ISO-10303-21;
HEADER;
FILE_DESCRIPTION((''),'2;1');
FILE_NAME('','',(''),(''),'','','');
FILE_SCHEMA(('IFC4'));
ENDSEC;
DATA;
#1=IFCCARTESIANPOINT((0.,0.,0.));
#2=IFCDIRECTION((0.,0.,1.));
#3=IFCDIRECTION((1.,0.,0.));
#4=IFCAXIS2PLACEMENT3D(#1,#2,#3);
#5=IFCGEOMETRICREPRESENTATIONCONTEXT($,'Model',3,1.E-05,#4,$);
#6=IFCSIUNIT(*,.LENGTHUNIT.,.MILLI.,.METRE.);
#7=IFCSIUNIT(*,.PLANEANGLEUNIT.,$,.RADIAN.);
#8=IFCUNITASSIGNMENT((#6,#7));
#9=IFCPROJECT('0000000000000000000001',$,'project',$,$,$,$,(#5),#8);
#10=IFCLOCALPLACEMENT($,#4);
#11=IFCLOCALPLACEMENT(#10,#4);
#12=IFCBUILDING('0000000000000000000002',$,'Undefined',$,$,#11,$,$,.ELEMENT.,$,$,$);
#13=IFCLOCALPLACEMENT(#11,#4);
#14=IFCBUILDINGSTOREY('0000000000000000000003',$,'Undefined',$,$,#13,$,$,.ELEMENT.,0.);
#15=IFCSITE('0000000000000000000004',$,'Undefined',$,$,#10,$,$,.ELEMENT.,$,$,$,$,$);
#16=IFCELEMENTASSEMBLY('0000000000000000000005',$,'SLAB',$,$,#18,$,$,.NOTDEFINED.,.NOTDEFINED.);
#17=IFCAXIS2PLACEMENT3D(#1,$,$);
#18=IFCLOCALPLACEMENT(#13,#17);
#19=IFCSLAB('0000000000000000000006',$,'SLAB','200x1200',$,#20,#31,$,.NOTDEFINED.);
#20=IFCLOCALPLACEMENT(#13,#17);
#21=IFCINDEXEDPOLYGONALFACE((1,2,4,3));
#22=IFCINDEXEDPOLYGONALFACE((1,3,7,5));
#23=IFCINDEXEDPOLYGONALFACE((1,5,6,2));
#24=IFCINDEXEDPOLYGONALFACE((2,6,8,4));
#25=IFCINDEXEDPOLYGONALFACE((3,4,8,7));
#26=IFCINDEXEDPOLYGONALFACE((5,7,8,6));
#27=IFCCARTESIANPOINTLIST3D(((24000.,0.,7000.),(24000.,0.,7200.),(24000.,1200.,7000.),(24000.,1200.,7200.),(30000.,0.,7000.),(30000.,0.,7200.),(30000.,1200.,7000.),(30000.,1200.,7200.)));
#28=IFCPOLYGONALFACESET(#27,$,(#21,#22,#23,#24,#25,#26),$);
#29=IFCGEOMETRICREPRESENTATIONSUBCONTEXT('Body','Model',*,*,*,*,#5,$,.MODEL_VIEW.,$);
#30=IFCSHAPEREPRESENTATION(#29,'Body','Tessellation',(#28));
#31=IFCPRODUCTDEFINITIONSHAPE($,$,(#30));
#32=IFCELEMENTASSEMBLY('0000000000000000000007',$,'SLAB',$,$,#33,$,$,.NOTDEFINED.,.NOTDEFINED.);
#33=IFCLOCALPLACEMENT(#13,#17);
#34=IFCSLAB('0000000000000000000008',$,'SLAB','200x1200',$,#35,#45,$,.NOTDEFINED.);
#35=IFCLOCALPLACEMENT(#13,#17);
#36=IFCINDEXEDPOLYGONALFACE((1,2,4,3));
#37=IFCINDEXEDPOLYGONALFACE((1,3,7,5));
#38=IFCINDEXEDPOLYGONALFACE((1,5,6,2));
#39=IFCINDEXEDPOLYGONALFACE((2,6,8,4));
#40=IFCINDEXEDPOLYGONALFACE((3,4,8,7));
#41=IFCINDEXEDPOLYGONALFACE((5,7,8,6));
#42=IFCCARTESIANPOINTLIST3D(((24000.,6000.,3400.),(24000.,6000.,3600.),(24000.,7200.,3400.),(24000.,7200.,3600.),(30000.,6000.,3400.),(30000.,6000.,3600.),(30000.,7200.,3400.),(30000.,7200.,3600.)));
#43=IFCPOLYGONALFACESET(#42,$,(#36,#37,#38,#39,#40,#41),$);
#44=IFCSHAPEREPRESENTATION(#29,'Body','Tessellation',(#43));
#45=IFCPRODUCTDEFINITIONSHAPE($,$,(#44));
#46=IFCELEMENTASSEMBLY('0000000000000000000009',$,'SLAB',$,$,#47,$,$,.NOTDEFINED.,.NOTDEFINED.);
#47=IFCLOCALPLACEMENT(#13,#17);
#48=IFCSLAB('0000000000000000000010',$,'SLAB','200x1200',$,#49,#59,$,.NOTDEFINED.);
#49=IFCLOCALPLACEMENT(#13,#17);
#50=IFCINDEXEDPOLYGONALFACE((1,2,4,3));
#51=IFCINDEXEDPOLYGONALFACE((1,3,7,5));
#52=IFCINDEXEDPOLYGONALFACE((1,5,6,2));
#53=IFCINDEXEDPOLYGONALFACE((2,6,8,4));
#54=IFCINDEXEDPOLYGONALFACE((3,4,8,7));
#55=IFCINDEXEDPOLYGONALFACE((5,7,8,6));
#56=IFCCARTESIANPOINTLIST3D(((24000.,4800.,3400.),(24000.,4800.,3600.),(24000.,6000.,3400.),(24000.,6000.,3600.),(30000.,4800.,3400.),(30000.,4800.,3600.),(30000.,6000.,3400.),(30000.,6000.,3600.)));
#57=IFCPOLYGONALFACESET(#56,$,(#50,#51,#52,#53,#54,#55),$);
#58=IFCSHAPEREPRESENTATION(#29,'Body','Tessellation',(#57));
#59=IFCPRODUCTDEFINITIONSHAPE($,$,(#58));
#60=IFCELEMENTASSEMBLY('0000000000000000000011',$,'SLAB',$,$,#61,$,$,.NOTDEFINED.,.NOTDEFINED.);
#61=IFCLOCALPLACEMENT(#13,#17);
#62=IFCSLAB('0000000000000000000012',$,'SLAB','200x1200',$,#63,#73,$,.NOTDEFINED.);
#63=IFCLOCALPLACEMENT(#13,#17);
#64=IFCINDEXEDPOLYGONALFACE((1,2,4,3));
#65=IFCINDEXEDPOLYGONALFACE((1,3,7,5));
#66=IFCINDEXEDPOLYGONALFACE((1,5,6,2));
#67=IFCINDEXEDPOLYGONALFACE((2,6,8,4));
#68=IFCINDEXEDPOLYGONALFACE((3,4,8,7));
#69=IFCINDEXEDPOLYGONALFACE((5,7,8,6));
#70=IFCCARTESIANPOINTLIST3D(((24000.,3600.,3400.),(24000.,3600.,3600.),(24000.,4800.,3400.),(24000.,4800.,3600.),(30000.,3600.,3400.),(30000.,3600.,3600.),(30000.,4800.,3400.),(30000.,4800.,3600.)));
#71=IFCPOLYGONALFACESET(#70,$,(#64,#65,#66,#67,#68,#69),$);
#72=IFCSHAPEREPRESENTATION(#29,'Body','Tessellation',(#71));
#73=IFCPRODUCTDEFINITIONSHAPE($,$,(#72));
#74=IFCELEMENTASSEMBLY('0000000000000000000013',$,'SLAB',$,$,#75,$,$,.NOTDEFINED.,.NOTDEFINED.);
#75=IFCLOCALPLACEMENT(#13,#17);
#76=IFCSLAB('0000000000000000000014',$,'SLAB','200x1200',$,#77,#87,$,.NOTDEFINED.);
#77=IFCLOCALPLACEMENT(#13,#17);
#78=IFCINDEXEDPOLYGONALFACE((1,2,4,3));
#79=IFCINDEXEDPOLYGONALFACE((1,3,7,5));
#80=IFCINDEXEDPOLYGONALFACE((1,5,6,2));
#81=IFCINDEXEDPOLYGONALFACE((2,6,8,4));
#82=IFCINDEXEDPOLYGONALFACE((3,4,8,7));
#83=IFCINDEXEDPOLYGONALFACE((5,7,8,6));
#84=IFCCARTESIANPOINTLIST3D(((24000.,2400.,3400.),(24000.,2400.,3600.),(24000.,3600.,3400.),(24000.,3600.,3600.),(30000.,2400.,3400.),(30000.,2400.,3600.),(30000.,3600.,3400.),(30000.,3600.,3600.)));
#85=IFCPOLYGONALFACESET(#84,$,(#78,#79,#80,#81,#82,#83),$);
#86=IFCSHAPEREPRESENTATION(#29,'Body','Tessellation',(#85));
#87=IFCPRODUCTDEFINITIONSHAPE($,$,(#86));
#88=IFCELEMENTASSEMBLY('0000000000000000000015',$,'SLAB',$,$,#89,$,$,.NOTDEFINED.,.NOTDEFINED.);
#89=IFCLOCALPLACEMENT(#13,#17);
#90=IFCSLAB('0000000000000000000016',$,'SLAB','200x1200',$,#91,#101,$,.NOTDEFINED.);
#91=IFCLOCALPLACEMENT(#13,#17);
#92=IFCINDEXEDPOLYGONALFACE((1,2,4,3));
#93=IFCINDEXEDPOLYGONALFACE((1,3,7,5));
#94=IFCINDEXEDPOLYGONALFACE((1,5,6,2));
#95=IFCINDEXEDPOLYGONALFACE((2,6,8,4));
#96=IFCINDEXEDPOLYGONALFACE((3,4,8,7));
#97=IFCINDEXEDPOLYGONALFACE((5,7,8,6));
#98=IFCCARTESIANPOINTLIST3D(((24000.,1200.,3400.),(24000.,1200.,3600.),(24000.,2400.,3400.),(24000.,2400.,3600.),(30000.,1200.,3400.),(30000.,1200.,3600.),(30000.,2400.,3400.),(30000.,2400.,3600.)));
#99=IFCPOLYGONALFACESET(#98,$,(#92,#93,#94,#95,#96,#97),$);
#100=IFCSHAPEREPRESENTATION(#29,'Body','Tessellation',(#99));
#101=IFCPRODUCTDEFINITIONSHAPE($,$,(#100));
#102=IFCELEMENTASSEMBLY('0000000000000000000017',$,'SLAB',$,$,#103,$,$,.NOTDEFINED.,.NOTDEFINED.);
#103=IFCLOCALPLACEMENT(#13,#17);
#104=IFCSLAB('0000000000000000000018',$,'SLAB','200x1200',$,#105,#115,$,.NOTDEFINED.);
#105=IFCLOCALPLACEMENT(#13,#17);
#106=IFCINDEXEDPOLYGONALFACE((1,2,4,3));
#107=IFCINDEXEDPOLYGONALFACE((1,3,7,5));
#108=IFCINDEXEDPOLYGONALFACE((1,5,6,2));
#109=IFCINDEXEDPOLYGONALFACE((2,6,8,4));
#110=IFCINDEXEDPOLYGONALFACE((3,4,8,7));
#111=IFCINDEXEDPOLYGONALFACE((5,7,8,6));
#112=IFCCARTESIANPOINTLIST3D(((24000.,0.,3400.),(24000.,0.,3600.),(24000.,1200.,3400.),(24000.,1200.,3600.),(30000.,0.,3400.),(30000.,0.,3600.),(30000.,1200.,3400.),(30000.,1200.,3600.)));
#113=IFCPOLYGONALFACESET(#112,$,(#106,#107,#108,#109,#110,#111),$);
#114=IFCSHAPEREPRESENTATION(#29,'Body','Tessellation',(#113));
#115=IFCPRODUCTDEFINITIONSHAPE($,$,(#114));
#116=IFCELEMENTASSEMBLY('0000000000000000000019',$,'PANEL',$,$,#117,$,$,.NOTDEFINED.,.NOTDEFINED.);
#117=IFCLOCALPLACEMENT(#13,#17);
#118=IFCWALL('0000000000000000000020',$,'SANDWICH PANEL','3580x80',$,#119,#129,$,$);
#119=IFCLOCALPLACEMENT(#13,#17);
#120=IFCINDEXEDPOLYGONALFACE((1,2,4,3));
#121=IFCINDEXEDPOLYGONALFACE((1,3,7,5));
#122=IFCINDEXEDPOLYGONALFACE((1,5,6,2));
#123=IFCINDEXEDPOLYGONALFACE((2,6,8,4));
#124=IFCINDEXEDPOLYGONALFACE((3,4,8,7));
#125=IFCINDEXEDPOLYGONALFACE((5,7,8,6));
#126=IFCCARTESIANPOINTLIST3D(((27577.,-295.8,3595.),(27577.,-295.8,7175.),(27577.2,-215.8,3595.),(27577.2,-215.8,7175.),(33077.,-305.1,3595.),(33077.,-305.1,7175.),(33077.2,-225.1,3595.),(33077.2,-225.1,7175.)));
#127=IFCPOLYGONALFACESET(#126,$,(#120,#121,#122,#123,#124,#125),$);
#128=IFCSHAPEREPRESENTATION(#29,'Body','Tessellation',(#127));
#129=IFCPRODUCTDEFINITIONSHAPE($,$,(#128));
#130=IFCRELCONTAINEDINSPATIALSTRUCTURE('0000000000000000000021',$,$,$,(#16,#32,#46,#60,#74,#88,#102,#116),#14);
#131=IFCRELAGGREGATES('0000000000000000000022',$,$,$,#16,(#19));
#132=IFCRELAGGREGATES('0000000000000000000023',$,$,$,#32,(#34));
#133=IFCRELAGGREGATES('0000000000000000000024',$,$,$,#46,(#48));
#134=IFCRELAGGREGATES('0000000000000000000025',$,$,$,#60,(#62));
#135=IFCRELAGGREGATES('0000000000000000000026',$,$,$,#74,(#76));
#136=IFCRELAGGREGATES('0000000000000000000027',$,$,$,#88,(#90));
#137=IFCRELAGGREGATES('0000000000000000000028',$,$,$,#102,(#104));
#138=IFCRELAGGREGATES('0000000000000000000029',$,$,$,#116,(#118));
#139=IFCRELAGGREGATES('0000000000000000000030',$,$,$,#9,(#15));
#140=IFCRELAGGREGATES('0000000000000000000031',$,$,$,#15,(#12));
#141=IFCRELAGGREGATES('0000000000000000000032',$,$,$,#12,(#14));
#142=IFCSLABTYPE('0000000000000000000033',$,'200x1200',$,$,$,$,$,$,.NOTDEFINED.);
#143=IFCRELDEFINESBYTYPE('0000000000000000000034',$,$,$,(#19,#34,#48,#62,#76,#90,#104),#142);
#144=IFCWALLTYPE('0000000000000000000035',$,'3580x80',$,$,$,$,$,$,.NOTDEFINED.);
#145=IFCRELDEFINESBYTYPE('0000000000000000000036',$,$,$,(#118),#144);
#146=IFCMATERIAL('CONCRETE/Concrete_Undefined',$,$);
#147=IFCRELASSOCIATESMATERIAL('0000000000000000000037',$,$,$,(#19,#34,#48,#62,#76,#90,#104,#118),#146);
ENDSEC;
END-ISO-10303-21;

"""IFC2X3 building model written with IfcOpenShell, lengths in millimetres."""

from ifc_helpers import new_model, si_unit, frame, frame_2d, origin_with_axes, place, context, subcontext, project, spatial, polyline, rectangle, outline, extrude, material, type_object, element, aggregate, save


model = new_model("IFC2X3")

# Units and contexts
model_context = context("Model", 3, precision=1e-05, world=origin_with_axes())
body_context = subcontext(model_context, "Body", "Model", "MODEL_VIEW")
ifc_project = project(units=[si_unit("LENGTHUNIT", "METRE", prefix="MILLI"), si_unit("PLANEANGLEUNIT", "RADIAN")], contexts=[model_context])

# Site, building, storey
site_placement = place(None, origin_with_axes())
site = spatial("IfcSite", under=ifc_project, at=site_placement, Name="Undefined", CompositionType="ELEMENT")
building_placement = place(site_placement, origin_with_axes())
building = spatial("IfcBuilding", under=site, at=building_placement, Name="Undefined", CompositionType="ELEMENT")
storey_placement = place(building_placement, origin_with_axes())
storey = spatial("IfcBuildingStorey", under=building, at=storey_placement, Name="Undefined", CompositionType="ELEMENT", Elevation=0.0)

# Shared definitions
ifc_material = material(Name="CONCRETE/Concrete_Undefined")

# Element assemblies, slabs
slab_type = type_object("IfcSlabType", Name="200x1200", PredefinedType="NOTDEFINED")
assembly_1_placement = place(storey_placement, origin_with_axes())
assembly_1 = element("IfcElementAssembly", 1, at=assembly_1_placement, inside=storey, Name="SLAB", AssemblyPlace="NOTDEFINED", PredefinedType="NOTDEFINED")
slab_1_placement = place(assembly_1_placement, frame((30000.0, 0.0, 7100.0), z_axis=(0.0, 0.0, 1.0), x_axis=(0.0, 1.0, 0.0)))
slab_1 = element("IfcSlab", 2, at=slab_1_placement, type_object=slab_type, material=ifc_material, Name="SLAB", Description="200x1200", PredefinedType="NOTDEFINED", context=body_context, shape_type="SweptSolid", body=[
    extrude(outline(polyline([(0.0, 0.0), (1200.0, 0.0), (1200.0, 6000.0), (0.0, 6000.0), (0.0, 0.0)])), frame((0.0, 0.0, -100.0), z_axis=(0.0, 0.0, 1.0), x_axis=(1.0, 0.0, 0.0)), (0.0, 0.0, 1.0), 200.0),
])
aggregate(assembly_1, [slab_1])
assembly_2_placement = place(storey_placement, origin_with_axes())
assembly_2 = element("IfcElementAssembly", 3, at=assembly_2_placement, inside=storey, Name="SLAB", AssemblyPlace="NOTDEFINED", PredefinedType="NOTDEFINED")
slab_2_placement = place(assembly_2_placement, frame((30000.0, 6000.0, 3500.0), z_axis=(0.0, 0.0, 1.0), x_axis=(0.0, 1.0, 0.0)))
slab_2 = element("IfcSlab", 4, at=slab_2_placement, type_object=slab_type, material=ifc_material, Name="SLAB", Description="200x1200", PredefinedType="NOTDEFINED", context=body_context, shape_type="SweptSolid", body=[
    extrude(outline(polyline([(0.0, 0.0), (1200.0, 0.0), (1200.0, 6000.0), (0.0, 6000.0), (0.0, 0.0)])), frame((0.0, 0.0, -100.0), z_axis=(0.0, 0.0, 1.0), x_axis=(1.0, 0.0, 0.0)), (0.0, 0.0, 1.0), 200.0),
])
aggregate(assembly_2, [slab_2])
assembly_3_placement = place(storey_placement, origin_with_axes())
assembly_3 = element("IfcElementAssembly", 5, at=assembly_3_placement, inside=storey, Name="SLAB", AssemblyPlace="NOTDEFINED", PredefinedType="NOTDEFINED")
slab_3_placement = place(assembly_3_placement, frame((30000.0, 4800.0, 3500.0), z_axis=(0.0, 0.0, 1.0), x_axis=(0.0, 1.0, 0.0)))
slab_3 = element("IfcSlab", 6, at=slab_3_placement, type_object=slab_type, material=ifc_material, Name="SLAB", Description="200x1200", PredefinedType="NOTDEFINED", context=body_context, shape_type="SweptSolid", body=[
    extrude(outline(polyline([(0.0, 0.0), (1200.0, 0.0), (1200.0, 6000.0), (0.0, 6000.0), (0.0, 0.0)])), frame((0.0, 0.0, -100.0), z_axis=(0.0, 0.0, 1.0), x_axis=(1.0, 0.0, 0.0)), (0.0, 0.0, 1.0), 200.0),
])
aggregate(assembly_3, [slab_3])
assembly_4_placement = place(storey_placement, origin_with_axes())
assembly_4 = element("IfcElementAssembly", 7, at=assembly_4_placement, inside=storey, Name="SLAB", AssemblyPlace="NOTDEFINED", PredefinedType="NOTDEFINED")
slab_4_placement = place(assembly_4_placement, frame((30000.0, 3600.0, 3500.0), z_axis=(0.0, 0.0, 1.0), x_axis=(0.0, 1.0, 0.0)))
slab_4 = element("IfcSlab", 8, at=slab_4_placement, type_object=slab_type, material=ifc_material, Name="SLAB", Description="200x1200", PredefinedType="NOTDEFINED", context=body_context, shape_type="SweptSolid", body=[
    extrude(outline(polyline([(0.0, 0.0), (1200.0, 0.0), (1200.0, 6000.0), (0.0, 6000.0), (0.0, 0.0)])), frame((0.0, 0.0, -100.0), z_axis=(0.0, 0.0, 1.0), x_axis=(1.0, 0.0, 0.0)), (0.0, 0.0, 1.0), 200.0),
])
aggregate(assembly_4, [slab_4])
assembly_5_placement = place(storey_placement, origin_with_axes())
assembly_5 = element("IfcElementAssembly", 9, at=assembly_5_placement, inside=storey, Name="SLAB", AssemblyPlace="NOTDEFINED", PredefinedType="NOTDEFINED")
slab_5_placement = place(assembly_5_placement, frame((30000.0, 2400.0, 3500.0), z_axis=(0.0, 0.0, 1.0), x_axis=(0.0, 1.0, 0.0)))
slab_5 = element("IfcSlab", 10, at=slab_5_placement, type_object=slab_type, material=ifc_material, Name="SLAB", Description="200x1200", PredefinedType="NOTDEFINED", context=body_context, shape_type="SweptSolid", body=[
    extrude(outline(polyline([(0.0, 0.0), (1200.0, 0.0), (1200.0, 6000.0), (0.0, 6000.0), (0.0, 0.0)])), frame((0.0, 0.0, -100.0), z_axis=(0.0, 0.0, 1.0), x_axis=(1.0, 0.0, 0.0)), (0.0, 0.0, 1.0), 200.0),
])
aggregate(assembly_5, [slab_5])
assembly_6_placement = place(storey_placement, origin_with_axes())
assembly_6 = element("IfcElementAssembly", 11, at=assembly_6_placement, inside=storey, Name="SLAB", AssemblyPlace="NOTDEFINED", PredefinedType="NOTDEFINED")
slab_6_placement = place(assembly_6_placement, frame((30000.0, 1200.0, 3500.0), z_axis=(0.0, 0.0, 1.0), x_axis=(0.0, 1.0, 0.0)))
slab_6 = element("IfcSlab", 12, at=slab_6_placement, type_object=slab_type, material=ifc_material, Name="SLAB", Description="200x1200", PredefinedType="NOTDEFINED", context=body_context, shape_type="SweptSolid", body=[
    extrude(outline(polyline([(0.0, 0.0), (1200.0, 0.0), (1200.0, 6000.0), (0.0, 6000.0), (0.0, 0.0)])), frame((0.0, 0.0, -100.0), z_axis=(0.0, 0.0, 1.0), x_axis=(1.0, 0.0, 0.0)), (0.0, 0.0, 1.0), 200.0),
])
aggregate(assembly_6, [slab_6])
assembly_7_placement = place(storey_placement, origin_with_axes())
assembly_7 = element("IfcElementAssembly", 13, at=assembly_7_placement, inside=storey, Name="SLAB", AssemblyPlace="NOTDEFINED", PredefinedType="NOTDEFINED")
slab_7_placement = place(assembly_7_placement, frame((30000.0, 0.0, 3500.0), z_axis=(0.0, 0.0, 1.0), x_axis=(0.0, 1.0, 0.0)))
slab_7 = element("IfcSlab", 14, at=slab_7_placement, type_object=slab_type, material=ifc_material, Name="SLAB", Description="200x1200", PredefinedType="NOTDEFINED", context=body_context, shape_type="SweptSolid", body=[
    extrude(outline(polyline([(0.0, 0.0), (1200.0, 0.0), (1200.0, 6000.0), (0.0, 6000.0), (0.0, 0.0)])), frame((0.0, 0.0, -100.0), z_axis=(0.0, 0.0, 1.0), x_axis=(1.0, 0.0, 0.0)), (0.0, 0.0, 1.0), 200.0),
])
aggregate(assembly_7, [slab_7])

# Element assembly, wall
assembly_8_placement = place(storey_placement, origin_with_axes())
assembly_8 = element("IfcElementAssembly", 15, at=assembly_8_placement, inside=storey, Name="PANEL", AssemblyPlace="NOTDEFINED", PredefinedType="NOTDEFINED")
wall_type = type_object("IfcWallType", Name="3580x80", PredefinedType="NOTDEFINED")
wall_placement = place(assembly_8_placement, frame((27577.1, -255.8, 3595.0), z_axis=(0.0, 0.0, 1.0), x_axis=(0.999999, -0.001684, 0.0)))
wall = element("IfcWall", 16, at=wall_placement, type_object=wall_type, material=ifc_material, Name="SANDWICH PANEL", Description="3580x80", context=body_context, shape_type="SweptSolid", body=[
    extrude(rectangle(XDim=5500.0, YDim=80.0, at=frame_2d((0.0, 2750.0), x_axis=(0.0, -1.0))), frame((0.0, 0.0, 0.0), z_axis=(0.0, 0.0, 1.0), x_axis=(0.0, -1.0, 0.0)), (0.0, 0.0, 1.0), 3580.0),
])
aggregate(assembly_8, [wall])

save(model, "model.ifc")
